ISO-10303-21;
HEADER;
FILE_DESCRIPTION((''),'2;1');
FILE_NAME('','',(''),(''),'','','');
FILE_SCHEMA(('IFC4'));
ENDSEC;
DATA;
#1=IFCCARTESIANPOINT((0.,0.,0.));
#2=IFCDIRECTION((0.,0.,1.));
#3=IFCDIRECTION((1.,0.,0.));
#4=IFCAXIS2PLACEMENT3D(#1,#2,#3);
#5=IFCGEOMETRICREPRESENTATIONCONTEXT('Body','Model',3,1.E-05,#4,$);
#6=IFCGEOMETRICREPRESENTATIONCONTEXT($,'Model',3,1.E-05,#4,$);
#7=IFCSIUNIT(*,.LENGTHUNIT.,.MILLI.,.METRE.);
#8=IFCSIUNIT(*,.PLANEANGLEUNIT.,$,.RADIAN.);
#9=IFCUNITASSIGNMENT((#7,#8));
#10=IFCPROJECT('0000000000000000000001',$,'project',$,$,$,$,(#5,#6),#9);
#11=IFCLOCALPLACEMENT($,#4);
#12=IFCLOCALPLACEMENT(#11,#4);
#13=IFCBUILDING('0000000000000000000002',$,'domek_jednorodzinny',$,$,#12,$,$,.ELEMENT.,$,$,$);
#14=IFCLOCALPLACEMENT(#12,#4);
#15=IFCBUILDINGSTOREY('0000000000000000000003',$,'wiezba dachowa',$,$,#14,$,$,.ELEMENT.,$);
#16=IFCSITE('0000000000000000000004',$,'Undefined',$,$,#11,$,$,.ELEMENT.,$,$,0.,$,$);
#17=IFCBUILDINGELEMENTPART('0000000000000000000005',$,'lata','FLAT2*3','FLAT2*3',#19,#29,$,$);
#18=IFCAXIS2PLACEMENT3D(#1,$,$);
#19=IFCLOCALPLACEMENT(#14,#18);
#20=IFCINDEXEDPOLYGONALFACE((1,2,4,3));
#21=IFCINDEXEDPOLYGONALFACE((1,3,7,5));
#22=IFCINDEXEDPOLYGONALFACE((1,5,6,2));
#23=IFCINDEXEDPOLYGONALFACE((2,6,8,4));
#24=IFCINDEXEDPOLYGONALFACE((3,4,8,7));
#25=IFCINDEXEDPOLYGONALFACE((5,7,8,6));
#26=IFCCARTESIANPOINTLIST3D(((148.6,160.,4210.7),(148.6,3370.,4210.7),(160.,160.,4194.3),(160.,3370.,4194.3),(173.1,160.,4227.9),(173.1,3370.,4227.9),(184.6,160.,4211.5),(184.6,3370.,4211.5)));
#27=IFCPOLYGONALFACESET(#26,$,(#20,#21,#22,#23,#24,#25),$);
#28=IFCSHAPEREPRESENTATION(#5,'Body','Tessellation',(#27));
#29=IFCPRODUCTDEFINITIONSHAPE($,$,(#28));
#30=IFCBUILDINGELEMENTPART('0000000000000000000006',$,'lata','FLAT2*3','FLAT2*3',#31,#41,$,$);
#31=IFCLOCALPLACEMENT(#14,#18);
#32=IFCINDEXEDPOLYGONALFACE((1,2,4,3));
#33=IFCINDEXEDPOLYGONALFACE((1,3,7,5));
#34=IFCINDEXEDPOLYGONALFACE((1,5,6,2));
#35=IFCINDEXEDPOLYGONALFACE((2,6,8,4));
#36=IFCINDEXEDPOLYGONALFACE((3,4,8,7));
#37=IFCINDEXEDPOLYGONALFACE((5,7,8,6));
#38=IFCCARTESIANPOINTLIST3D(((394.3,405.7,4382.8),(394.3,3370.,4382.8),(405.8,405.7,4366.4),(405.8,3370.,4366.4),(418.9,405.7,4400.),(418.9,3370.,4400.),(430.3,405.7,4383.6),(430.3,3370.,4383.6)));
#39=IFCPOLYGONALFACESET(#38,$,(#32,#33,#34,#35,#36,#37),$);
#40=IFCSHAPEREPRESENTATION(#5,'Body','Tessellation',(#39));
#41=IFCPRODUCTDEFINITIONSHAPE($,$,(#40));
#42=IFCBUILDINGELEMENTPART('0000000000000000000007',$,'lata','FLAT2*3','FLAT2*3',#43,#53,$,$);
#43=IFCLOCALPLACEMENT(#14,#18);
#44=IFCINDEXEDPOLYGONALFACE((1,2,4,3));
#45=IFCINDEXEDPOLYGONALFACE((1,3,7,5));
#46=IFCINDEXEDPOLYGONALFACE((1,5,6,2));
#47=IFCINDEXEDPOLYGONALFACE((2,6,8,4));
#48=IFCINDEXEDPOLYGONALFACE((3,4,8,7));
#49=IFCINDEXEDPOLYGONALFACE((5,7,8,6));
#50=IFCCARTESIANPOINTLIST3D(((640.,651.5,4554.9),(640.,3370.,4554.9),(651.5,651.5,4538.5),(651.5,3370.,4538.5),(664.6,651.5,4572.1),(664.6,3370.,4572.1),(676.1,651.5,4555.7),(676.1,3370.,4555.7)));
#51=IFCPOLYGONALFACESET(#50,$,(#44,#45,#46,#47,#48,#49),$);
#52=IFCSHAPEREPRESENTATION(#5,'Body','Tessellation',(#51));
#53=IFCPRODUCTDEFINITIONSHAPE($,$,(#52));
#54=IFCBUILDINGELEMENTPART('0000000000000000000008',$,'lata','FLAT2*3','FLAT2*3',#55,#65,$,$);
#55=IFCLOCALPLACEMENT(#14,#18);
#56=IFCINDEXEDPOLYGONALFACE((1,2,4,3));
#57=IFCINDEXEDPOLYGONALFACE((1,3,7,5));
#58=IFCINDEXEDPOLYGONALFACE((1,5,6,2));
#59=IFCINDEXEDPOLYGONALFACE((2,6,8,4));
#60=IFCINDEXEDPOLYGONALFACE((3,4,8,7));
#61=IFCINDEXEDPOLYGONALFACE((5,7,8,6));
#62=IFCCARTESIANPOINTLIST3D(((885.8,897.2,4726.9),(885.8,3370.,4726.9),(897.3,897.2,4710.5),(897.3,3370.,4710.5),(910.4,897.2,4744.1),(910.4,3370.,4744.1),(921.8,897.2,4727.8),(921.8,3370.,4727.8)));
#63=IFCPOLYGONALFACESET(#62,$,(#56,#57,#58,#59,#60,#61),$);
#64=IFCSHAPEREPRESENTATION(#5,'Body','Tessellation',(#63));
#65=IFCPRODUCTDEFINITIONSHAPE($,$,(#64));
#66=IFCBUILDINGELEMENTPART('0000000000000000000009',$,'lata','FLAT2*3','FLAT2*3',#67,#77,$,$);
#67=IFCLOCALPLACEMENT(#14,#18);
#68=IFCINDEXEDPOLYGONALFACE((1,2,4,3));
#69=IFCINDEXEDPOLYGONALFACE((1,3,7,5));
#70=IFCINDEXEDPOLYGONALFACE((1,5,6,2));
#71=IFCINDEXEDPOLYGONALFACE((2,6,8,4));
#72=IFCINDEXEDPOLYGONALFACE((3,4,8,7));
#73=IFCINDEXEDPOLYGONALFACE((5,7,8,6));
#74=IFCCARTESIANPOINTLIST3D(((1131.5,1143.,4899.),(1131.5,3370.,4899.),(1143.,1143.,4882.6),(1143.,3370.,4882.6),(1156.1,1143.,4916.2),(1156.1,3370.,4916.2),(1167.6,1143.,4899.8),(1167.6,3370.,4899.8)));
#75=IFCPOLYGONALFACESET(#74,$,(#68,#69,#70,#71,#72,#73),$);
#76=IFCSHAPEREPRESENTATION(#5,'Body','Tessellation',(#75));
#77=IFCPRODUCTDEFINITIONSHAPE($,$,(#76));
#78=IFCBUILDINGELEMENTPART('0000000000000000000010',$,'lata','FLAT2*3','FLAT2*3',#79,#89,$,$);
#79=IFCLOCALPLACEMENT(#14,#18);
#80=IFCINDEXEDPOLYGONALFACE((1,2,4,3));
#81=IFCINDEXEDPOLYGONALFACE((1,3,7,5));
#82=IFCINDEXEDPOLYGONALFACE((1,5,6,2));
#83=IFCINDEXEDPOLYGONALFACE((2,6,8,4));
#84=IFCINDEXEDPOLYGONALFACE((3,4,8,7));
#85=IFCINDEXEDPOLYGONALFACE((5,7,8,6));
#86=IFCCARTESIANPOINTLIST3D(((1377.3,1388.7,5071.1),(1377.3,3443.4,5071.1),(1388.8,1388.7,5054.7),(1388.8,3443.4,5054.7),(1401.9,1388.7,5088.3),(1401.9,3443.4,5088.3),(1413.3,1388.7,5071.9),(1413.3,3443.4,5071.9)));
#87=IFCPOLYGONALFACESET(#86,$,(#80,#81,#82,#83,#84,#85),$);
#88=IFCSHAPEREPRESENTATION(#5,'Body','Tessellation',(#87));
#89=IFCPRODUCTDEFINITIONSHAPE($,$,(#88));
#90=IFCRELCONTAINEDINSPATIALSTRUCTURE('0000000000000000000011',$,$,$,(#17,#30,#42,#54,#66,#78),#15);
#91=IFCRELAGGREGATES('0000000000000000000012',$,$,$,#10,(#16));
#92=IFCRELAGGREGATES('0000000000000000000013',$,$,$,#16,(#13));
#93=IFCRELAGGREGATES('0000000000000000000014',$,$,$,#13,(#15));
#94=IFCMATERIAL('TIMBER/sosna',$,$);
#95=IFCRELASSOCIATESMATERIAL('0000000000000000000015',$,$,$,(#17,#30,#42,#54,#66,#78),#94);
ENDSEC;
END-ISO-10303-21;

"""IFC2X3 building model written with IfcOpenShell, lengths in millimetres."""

from ifc_helpers import new_model, si_unit, frame, origin_with_axes, origin_2d_with_axis, place, context, project, spatial, rectangle, extrude, material, element, save


model = new_model("IFC2X3")

# Units and contexts
model_context_1 = context("Model", 3, precision=1e-05, world=origin_with_axes(), identifier="Body")
model_context_2 = context("Model", 3, precision=1e-05, world=origin_with_axes())
ifc_project = project(units=[si_unit("LENGTHUNIT", "METRE", prefix="MILLI"), si_unit("PLANEANGLEUNIT", "RADIAN")], contexts=[model_context_1, model_context_2])

# Site, building, storey
site_placement = place(None, origin_with_axes())
site = spatial("IfcSite", under=ifc_project, at=site_placement, Name="Undefined", CompositionType="ELEMENT", RefElevation=0.0)
building_placement = place(site_placement, origin_with_axes())
building = spatial("IfcBuilding", under=site, at=building_placement, Name="domek_jednorodzinny", CompositionType="ELEMENT")
storey_placement = place(building_placement, origin_with_axes())
storey = spatial("IfcBuildingStorey", under=building, at=storey_placement, Name="wiezba dachowa", CompositionType="ELEMENT")

# Building element parts
ifc_material = material(Name="TIMBER/sosna")
building_element_part_1_placement = place(storey_placement, frame((166.6, 160.0, 4211.1), z_axis=(0.819152, 0.0, 0.573576), x_axis=(0.0, 1.0, 0.0)))
element("IfcBuildingElementPart", 1, at=building_element_part_1_placement, inside=storey, material=ifc_material, Name="lata", Description="FLAT2*3", ObjectType="FLAT2*3", context=model_context_1, shape_type="SweptSolid", body=[
    extrude(rectangle(XDim=20.0, YDim=30.0, at=origin_2d_with_axis()), frame((3210.0, 0.0, 0.0), z_axis=(-1.0, 0.0, 0.0), x_axis=(0.0, -1.0, 0.0)), (0.0, 0.0, 1.0), 3210.0),
])
building_element_part_2_placement = place(storey_placement, frame((412.3, 405.7, 4383.2), z_axis=(0.819152, 0.0, 0.573576), x_axis=(0.0, 1.0, 0.0)))
element("IfcBuildingElementPart", 2, at=building_element_part_2_placement, inside=storey, material=ifc_material, Name="lata", Description="FLAT2*3", ObjectType="FLAT2*3", context=model_context_1, shape_type="SweptSolid", body=[
    extrude(rectangle(XDim=20.0, YDim=30.0, at=origin_2d_with_axis()), frame((2964.3, 0.0, 0.0), z_axis=(-1.0, 0.0, 0.0), x_axis=(0.0, -1.0, 0.0)), (0.0, 0.0, 1.0), 2964.3),
])
building_element_part_3_placement = place(storey_placement, frame((658.1, 651.5, 4555.3), z_axis=(0.819152, 0.0, 0.573576), x_axis=(0.0, 1.0, 0.0)))
element("IfcBuildingElementPart", 3, at=building_element_part_3_placement, inside=storey, material=ifc_material, Name="lata", Description="FLAT2*3", ObjectType="FLAT2*3", context=model_context_1, shape_type="SweptSolid", body=[
    extrude(rectangle(XDim=20.0, YDim=30.0, at=origin_2d_with_axis()), frame((2718.5, 0.0, 0.0), z_axis=(-1.0, 0.0, 0.0), x_axis=(0.0, -1.0, 0.0)), (0.0, 0.0, 1.0), 2718.5),
])
building_element_part_4_placement = place(storey_placement, frame((903.8, 897.2, 4727.3), z_axis=(0.819152, 0.0, 0.573576), x_axis=(0.0, 1.0, 0.0)))
element("IfcBuildingElementPart", 4, at=building_element_part_4_placement, inside=storey, material=ifc_material, Name="lata", Description="FLAT2*3", ObjectType="FLAT2*3", context=model_context_1, shape_type="SweptSolid", body=[
    extrude(rectangle(XDim=20.0, YDim=30.0, at=origin_2d_with_axis()), frame((2472.8, 0.0, 0.0), z_axis=(-1.0, 0.0, 0.0), x_axis=(0.0, -1.0, 0.0)), (0.0, 0.0, 1.0), 2472.8),
])
building_element_part_5_placement = place(storey_placement, frame((1149.6, 1143.0, 4899.4), z_axis=(0.819152, 0.0, 0.573576), x_axis=(0.0, 1.0, 0.0)))
element("IfcBuildingElementPart", 5, at=building_element_part_5_placement, inside=storey, material=ifc_material, Name="lata", Description="FLAT2*3", ObjectType="FLAT2*3", context=model_context_1, shape_type="SweptSolid", body=[
    extrude(rectangle(XDim=20.0, YDim=30.0, at=origin_2d_with_axis()), frame((2227.0, 0.0, 0.0), z_axis=(-1.0, 0.0, 0.0), x_axis=(0.0, -1.0, 0.0)), (0.0, 0.0, 1.0), 2227.0),
])
building_element_part_6_placement = place(storey_placement, frame((1395.3, 1388.7, 5071.5), z_axis=(0.819152, 0.0, 0.573576), x_axis=(0.0, 1.0, 0.0)))
element("IfcBuildingElementPart", 6, at=building_element_part_6_placement, inside=storey, material=ifc_material, Name="lata", Description="FLAT2*3", ObjectType="FLAT2*3", context=model_context_1, shape_type="SweptSolid", body=[
    extrude(rectangle(XDim=20.0, YDim=30.0, at=origin_2d_with_axis()), frame((2054.7, 0.0, 0.0), z_axis=(-1.0, 0.0, 0.0), x_axis=(0.0, -1.0, 0.0)), (0.0, 0.0, 1.0), 2054.7),
])

save(model, "model.ifc")
